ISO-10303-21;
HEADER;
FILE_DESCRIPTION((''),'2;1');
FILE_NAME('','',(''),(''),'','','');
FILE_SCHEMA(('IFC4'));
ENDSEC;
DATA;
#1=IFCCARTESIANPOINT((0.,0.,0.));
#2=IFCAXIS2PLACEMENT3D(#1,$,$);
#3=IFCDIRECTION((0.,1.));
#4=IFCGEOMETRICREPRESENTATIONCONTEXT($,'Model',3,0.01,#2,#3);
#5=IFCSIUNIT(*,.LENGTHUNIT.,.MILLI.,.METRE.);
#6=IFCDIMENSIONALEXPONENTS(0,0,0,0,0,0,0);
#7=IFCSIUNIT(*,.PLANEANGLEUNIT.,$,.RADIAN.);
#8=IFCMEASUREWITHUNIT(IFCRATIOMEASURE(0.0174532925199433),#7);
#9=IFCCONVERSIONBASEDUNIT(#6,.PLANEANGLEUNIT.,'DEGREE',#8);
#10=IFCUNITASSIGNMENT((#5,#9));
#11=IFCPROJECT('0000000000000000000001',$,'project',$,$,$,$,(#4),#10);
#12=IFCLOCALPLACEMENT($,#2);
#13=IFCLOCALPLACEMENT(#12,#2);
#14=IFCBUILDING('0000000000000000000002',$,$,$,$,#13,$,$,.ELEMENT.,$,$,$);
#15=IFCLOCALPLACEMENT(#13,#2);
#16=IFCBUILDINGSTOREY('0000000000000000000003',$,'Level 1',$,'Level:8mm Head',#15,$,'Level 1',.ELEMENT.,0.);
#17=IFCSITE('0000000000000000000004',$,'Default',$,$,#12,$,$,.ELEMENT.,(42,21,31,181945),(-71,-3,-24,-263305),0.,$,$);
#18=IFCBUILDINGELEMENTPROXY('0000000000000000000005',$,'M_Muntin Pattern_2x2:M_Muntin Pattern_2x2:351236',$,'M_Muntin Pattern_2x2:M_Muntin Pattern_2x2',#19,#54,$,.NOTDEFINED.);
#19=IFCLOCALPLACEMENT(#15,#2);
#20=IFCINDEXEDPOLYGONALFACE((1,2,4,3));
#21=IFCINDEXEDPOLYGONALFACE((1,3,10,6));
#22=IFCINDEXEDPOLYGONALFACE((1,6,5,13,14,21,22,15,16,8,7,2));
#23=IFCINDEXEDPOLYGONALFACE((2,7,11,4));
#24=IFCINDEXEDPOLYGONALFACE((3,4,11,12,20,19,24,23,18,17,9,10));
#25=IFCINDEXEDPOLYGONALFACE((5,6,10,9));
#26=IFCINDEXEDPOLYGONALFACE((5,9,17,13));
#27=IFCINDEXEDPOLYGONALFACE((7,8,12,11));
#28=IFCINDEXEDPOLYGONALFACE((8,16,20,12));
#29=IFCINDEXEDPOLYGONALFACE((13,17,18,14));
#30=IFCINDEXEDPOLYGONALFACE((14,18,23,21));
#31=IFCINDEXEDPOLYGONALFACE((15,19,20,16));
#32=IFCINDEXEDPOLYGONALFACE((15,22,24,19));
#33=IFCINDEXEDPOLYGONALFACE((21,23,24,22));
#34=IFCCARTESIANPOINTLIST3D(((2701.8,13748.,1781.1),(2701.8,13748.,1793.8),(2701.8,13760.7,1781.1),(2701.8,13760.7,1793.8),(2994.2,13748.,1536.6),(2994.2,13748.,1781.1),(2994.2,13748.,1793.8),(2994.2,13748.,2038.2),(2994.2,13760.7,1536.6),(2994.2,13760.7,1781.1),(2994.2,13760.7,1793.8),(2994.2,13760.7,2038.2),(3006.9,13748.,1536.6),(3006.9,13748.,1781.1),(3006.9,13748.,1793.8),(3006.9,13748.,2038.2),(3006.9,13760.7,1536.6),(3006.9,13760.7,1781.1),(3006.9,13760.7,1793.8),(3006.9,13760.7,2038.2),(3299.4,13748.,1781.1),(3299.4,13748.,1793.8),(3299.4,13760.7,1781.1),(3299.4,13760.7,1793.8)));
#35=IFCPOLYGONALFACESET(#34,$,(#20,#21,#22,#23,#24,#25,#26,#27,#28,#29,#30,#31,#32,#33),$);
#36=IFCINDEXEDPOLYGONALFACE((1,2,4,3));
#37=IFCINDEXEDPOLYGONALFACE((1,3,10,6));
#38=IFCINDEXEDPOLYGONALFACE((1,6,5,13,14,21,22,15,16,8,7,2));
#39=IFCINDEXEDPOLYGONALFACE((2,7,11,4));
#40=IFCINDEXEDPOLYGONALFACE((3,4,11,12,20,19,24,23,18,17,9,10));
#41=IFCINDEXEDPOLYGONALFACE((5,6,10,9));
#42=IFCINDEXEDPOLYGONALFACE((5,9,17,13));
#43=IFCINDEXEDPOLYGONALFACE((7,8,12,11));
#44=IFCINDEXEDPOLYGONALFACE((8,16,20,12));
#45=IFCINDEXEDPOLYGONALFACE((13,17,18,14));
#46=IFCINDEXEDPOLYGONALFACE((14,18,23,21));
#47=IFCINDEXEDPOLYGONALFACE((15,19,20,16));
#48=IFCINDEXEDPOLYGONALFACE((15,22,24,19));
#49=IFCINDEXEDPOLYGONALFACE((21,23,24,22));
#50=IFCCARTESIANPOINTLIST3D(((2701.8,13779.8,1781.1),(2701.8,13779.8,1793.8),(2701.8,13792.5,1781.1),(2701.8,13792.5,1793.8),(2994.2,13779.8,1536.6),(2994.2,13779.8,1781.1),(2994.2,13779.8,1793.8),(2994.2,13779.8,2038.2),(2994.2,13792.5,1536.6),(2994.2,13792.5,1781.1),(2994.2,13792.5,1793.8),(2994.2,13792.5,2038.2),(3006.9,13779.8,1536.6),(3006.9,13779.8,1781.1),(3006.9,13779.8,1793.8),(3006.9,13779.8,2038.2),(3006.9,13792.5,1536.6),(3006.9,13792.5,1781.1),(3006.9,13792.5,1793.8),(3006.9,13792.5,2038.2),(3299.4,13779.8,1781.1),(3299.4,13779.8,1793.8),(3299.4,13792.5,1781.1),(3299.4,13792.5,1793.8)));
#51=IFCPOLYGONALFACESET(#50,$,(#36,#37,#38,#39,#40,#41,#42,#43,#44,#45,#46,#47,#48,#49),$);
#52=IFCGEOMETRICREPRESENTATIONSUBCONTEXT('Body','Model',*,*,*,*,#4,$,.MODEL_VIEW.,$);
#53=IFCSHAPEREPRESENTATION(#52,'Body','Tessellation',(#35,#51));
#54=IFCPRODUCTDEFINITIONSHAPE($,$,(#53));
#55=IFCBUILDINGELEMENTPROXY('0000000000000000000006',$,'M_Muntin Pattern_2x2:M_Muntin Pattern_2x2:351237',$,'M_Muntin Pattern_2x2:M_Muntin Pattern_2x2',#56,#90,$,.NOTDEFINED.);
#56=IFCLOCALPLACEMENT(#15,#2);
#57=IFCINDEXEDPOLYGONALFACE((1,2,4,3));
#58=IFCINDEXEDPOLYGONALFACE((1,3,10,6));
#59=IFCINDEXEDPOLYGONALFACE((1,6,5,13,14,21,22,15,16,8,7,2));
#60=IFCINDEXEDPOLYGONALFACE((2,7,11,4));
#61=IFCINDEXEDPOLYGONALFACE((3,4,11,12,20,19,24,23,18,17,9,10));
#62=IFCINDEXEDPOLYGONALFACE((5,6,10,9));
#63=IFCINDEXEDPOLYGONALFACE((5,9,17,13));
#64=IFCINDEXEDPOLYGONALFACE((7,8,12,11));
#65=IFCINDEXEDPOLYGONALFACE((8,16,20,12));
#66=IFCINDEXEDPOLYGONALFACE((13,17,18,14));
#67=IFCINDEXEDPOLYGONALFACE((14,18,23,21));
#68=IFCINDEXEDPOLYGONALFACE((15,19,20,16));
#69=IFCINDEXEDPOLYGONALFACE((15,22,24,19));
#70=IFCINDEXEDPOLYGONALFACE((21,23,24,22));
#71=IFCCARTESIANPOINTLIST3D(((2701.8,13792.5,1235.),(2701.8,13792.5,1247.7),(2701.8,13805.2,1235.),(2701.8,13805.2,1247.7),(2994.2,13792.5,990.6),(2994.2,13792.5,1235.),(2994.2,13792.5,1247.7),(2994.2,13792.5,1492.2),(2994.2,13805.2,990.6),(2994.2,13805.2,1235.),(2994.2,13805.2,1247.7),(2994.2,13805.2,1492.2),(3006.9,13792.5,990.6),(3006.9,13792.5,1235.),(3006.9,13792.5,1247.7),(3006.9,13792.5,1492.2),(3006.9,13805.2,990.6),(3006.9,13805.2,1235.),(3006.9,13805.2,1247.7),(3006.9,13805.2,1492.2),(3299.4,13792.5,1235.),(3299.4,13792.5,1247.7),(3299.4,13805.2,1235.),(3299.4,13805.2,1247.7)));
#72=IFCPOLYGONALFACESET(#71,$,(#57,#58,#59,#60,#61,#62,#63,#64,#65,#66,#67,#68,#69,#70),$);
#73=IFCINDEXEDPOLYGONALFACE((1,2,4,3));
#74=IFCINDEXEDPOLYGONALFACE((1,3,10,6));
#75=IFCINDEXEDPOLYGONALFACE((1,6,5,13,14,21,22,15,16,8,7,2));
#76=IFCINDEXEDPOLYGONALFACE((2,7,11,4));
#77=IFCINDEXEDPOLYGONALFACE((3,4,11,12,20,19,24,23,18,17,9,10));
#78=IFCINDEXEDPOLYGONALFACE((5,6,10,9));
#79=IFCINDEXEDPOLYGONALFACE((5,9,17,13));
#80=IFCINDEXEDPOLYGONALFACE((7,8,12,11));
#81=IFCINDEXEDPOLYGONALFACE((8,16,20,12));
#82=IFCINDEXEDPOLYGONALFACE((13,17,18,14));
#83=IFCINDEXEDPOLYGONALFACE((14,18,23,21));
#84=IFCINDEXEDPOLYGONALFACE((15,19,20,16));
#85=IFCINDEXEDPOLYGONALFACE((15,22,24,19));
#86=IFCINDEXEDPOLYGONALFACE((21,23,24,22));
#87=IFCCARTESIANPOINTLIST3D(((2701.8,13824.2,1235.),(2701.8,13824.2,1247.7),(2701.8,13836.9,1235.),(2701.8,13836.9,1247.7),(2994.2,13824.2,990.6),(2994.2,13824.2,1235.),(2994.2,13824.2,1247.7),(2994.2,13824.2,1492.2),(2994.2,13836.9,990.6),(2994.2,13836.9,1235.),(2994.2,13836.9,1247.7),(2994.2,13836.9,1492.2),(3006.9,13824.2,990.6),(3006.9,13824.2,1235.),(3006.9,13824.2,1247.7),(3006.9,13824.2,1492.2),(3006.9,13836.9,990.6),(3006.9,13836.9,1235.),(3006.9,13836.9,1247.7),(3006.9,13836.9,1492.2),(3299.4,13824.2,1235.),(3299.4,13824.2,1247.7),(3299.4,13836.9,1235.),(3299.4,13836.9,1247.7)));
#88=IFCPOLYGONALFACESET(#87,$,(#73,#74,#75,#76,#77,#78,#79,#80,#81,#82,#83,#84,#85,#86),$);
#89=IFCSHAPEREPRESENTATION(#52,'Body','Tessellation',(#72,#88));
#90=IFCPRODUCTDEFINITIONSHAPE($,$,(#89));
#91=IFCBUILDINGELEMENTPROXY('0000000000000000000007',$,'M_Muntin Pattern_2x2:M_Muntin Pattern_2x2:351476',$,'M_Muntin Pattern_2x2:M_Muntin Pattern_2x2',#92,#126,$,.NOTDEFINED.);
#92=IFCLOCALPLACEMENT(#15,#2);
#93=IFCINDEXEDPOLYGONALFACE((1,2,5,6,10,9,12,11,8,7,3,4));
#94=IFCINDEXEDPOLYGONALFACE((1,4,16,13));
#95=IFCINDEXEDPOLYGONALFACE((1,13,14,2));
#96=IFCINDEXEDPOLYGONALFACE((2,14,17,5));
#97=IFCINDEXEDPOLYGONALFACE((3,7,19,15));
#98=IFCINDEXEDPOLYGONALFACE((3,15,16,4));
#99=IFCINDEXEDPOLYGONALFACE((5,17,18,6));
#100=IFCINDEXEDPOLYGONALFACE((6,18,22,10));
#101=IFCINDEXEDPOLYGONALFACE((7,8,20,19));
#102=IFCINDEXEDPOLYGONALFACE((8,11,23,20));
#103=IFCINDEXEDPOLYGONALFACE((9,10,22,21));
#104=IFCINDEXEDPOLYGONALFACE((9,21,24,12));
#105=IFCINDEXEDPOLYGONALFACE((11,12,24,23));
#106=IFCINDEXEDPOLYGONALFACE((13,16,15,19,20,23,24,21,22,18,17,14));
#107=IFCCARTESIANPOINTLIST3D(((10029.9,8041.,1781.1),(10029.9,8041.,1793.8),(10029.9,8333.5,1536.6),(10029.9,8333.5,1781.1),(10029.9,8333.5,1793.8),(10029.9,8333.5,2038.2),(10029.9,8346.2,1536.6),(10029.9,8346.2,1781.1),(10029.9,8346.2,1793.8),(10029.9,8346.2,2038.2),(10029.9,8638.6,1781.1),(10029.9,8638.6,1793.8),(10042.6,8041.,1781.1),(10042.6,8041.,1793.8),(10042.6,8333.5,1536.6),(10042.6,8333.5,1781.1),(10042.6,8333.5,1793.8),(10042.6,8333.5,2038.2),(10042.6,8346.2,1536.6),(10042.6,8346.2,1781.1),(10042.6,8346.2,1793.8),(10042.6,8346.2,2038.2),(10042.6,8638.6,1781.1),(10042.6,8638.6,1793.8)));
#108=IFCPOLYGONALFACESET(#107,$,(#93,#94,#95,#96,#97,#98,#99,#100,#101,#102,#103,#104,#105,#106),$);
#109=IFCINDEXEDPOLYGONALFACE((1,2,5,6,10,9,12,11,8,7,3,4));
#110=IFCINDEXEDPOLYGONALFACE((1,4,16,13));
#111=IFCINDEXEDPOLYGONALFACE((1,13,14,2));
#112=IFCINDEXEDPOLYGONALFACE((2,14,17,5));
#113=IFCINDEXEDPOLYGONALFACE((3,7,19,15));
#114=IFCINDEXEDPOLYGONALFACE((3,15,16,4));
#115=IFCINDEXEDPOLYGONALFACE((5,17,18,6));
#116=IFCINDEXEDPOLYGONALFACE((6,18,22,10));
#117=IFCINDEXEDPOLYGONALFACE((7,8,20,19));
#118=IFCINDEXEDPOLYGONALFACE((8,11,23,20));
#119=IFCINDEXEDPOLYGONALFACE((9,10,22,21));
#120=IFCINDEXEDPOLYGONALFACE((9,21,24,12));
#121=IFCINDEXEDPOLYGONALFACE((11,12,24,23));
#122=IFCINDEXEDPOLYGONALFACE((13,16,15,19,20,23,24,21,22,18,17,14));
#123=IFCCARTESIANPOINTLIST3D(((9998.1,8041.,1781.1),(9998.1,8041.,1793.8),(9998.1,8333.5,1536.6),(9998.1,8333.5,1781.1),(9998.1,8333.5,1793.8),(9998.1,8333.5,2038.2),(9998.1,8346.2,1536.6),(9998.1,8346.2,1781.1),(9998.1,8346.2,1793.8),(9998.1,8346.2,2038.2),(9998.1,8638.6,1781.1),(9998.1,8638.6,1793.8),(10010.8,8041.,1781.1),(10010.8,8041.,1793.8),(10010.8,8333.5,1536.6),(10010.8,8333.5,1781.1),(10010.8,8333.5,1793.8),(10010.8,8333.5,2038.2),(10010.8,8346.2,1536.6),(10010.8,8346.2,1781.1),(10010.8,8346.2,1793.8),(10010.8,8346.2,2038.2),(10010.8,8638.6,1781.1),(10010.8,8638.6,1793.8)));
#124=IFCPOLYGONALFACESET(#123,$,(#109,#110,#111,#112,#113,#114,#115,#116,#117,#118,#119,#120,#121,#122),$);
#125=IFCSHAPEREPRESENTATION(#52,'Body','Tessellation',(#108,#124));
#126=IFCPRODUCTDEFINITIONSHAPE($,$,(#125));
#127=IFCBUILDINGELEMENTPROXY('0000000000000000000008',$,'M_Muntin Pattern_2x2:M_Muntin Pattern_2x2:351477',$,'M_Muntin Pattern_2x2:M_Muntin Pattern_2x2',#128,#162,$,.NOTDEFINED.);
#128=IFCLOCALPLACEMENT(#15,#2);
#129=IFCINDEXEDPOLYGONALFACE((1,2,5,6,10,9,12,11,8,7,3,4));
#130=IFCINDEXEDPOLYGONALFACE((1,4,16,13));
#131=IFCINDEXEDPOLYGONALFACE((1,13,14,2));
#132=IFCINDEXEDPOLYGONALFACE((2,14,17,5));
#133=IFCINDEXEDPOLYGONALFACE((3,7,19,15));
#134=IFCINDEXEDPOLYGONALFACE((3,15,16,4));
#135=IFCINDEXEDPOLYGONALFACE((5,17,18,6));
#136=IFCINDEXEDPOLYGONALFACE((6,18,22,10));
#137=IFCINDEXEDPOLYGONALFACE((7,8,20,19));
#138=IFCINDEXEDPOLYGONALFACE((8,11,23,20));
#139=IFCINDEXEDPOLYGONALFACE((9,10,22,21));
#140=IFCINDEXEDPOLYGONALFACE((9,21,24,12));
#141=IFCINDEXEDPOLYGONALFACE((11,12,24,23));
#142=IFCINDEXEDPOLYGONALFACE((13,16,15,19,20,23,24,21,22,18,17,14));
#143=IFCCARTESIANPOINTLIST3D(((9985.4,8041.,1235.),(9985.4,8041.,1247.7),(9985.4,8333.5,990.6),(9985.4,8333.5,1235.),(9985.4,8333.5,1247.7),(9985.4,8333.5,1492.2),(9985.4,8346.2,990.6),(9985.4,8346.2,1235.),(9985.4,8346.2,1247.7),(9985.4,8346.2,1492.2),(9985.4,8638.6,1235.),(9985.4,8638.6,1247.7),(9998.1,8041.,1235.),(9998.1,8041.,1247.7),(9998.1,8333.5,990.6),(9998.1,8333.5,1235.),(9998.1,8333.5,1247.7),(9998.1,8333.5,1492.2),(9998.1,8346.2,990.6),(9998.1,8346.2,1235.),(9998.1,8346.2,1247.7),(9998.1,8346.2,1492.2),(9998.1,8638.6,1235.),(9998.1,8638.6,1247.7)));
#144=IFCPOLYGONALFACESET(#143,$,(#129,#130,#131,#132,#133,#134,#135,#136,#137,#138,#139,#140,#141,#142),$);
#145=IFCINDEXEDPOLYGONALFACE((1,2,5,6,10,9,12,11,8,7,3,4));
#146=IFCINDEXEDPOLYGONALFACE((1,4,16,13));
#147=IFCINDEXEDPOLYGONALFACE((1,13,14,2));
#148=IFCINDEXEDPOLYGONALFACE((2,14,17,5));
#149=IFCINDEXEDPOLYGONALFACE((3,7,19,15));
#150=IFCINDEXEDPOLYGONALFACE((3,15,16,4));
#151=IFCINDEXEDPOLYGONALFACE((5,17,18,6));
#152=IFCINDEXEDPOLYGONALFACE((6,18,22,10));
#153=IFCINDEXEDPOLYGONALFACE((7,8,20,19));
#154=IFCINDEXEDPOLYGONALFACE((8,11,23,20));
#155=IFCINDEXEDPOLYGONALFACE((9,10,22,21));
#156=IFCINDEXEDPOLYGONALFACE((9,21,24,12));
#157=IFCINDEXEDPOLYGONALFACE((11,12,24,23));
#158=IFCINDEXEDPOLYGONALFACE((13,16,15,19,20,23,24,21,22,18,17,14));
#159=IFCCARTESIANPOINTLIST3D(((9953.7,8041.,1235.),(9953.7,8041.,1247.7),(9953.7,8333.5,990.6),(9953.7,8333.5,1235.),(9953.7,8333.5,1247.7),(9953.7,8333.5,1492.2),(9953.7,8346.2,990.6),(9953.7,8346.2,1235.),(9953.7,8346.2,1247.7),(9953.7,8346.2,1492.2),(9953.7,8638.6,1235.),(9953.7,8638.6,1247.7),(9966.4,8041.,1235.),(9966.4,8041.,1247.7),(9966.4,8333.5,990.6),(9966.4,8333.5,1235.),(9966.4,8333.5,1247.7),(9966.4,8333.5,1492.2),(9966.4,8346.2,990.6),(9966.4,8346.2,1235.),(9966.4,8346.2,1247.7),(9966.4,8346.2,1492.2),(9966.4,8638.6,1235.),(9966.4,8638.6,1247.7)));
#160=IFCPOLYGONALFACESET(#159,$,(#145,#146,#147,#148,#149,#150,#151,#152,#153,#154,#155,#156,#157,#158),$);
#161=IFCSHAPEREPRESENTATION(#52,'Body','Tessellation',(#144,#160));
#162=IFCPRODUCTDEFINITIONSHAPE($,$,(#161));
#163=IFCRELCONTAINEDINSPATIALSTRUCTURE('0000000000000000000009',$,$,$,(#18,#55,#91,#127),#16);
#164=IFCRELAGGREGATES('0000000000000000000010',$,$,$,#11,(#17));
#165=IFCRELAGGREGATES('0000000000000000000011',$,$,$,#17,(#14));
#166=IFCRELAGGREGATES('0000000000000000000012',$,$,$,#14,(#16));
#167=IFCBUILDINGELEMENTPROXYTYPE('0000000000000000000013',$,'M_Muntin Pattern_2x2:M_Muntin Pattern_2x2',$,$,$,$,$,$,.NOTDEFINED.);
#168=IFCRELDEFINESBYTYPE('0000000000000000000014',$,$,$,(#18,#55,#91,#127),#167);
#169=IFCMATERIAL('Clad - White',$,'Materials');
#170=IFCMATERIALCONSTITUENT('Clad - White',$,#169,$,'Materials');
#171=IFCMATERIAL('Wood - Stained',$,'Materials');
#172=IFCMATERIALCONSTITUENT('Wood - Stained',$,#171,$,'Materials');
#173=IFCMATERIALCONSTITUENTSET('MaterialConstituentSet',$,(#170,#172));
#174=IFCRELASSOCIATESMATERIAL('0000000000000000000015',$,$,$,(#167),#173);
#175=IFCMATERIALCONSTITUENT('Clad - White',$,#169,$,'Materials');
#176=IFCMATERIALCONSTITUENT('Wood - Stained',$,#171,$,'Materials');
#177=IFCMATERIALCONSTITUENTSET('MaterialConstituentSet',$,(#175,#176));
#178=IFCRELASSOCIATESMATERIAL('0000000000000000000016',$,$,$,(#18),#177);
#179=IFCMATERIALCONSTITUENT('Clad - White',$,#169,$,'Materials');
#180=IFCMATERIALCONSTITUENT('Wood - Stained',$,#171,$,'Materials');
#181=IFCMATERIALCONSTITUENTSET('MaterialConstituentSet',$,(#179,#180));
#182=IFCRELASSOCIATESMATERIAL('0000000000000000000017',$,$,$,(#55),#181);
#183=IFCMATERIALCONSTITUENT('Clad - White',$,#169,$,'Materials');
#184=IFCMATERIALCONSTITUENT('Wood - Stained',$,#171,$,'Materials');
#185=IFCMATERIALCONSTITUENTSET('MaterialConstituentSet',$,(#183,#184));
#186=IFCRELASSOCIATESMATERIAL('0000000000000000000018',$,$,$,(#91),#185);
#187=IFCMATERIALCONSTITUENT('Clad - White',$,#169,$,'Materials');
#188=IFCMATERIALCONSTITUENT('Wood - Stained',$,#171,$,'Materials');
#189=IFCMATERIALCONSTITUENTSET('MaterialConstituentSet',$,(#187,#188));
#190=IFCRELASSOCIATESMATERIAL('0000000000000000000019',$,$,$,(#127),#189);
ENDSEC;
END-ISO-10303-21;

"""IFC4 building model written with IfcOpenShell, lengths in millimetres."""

from ifc_helpers import new_model, entity, si_unit, converted_unit, direction, frame, origin, place, context, subcontext, project, spatial, polyline, outline, extrude, source, transform, mapped, material, constituent, constituent_set, type_object, type_shapes, element, save


model = new_model("IFC4")

# Units and contexts
model_context = context("Model", 3, precision=0.01, world=origin(), true_north=direction((0.0, 1.0)))
body_context = subcontext(model_context, "Body", "Model", "MODEL_VIEW")
ifc_project = project(units=[si_unit("LENGTHUNIT", "METRE", prefix="MILLI"), converted_unit("PLANEANGLEUNIT", "DEGREE", entity("IfcRatioMeasure", 0.0174532925199433), si_unit("PLANEANGLEUNIT", "RADIAN"), dimensions=[0, 0, 0, 0, 0, 0, 0])], contexts=[model_context])

# Site, building, storey
site_placement = place(None, origin())
site = spatial("IfcSite", under=ifc_project, at=site_placement, Name="Default", CompositionType="ELEMENT", RefLatitude=(42, 21, 31, 181945), RefLongitude=(-71, -3, -24, -263305), RefElevation=0.0)
building_placement = place(site_placement, origin())
building = spatial("IfcBuilding", under=site, at=building_placement, CompositionType="ELEMENT")
storey_placement = place(building_placement, origin())
storey = spatial("IfcBuildingStorey", under=building, at=storey_placement, Name="Level 1", ObjectType="Level:8mm Head", LongName="Level 1", CompositionType="ELEMENT", Elevation=0.0)

# Shared definitions
ifc_material_1 = material(Name="Wood - Stained", Category="Materials")

# Building element proxies
ifc_material_2 = material(Name="Clad - White", Category="Materials")
ifc_constituent_1 = constituent(ifc_material_2, Name="Clad - White", Category="Materials")
ifc_constituent_2 = constituent(ifc_material_1, Name="Wood - Stained", Category="Materials")
ifc_constituent_set_1 = constituent_set(constituents=[ifc_constituent_1, ifc_constituent_2], Name="MaterialConstituentSet")
building_element_proxy_type_1 = type_object("IfcBuildingElementProxyType", Name="M_Muntin Pattern_2x2:M_Muntin Pattern_2x2", PredefinedType="NOTDEFINED", material=ifc_constituent_set_1)
shared_shape_1 = source(origin(), body_context, "Body", "SweptSolid", [
    extrude(outline(polyline([(6.4, -6.4), (250.8, -6.4), (250.8, 6.3), (6.4, 6.3), (6.4, 298.8), (-6.3, 298.8), (-6.3, 6.3), (-250.8, 6.3), (-250.8, -6.4), (-6.3, -6.4), (-6.3, -298.8), (6.4, -298.8), (6.4, -6.4)])), frame((0.0, 9.5, 250.8), z_axis=(0.0, 1.0, 0.0), x_axis=(0.0, 0.0, 1.0)), (0.0, 0.0, 1.0), 12.7),
    extrude(outline(polyline([(6.4, -6.4), (250.8, -6.4), (250.8, 6.3), (6.4, 6.3), (6.4, 298.8), (-6.3, 298.8), (-6.3, 6.3), (-250.8, 6.3), (-250.8, -6.4), (-6.3, -6.4), (-6.3, -298.8), (6.4, -298.8), (6.4, -6.4)])), frame((0.0, -22.2, 250.8), z_axis=(0.0, 1.0, 0.0), x_axis=(0.0, 0.0, 1.0)), (0.0, 0.0, 1.0), 12.7),
])
type_shapes(building_element_proxy_type_1, [shared_shape_1])
ifc_constituent_3 = constituent(ifc_material_2, Name="Clad - White", Category="Materials")
ifc_constituent_4 = constituent(ifc_material_1, Name="Wood - Stained", Category="Materials")
ifc_constituent_set_2 = constituent_set(constituents=[ifc_constituent_3, ifc_constituent_4], Name="MaterialConstituentSet")
proxy_1_placement = place(storey_placement, frame((3000.6, 13770.3, 1536.6), z_axis=(0.0, 0.0, 1.0), x_axis=(-1.0, 0.0, 0.0)))
element("IfcBuildingElementProxy", 1, at=proxy_1_placement, inside=storey, type_object=building_element_proxy_type_1, material=ifc_constituent_set_2, Name="M_Muntin Pattern_2x2:M_Muntin Pattern_2x2:351236", ObjectType="M_Muntin Pattern_2x2:M_Muntin Pattern_2x2", PredefinedType="NOTDEFINED", context=body_context, shape_type="MappedRepresentation", body=[
    mapped(shared_shape_1, transform((0.0, 0.0, 0.0), scale=1.0)),
])
ifc_constituent_5 = constituent(ifc_material_2, Name="Clad - White", Category="Materials")
ifc_constituent_6 = constituent(ifc_material_1, Name="Wood - Stained", Category="Materials")
ifc_constituent_set_3 = constituent_set(constituents=[ifc_constituent_5, ifc_constituent_6], Name="MaterialConstituentSet")
proxy_2_placement = place(storey_placement, frame((3000.6, 13814.7, 990.6), z_axis=(0.0, 0.0, 1.0), x_axis=(-1.0, 0.0, 0.0)))
element("IfcBuildingElementProxy", 2, at=proxy_2_placement, inside=storey, type_object=building_element_proxy_type_1, material=ifc_constituent_set_3, Name="M_Muntin Pattern_2x2:M_Muntin Pattern_2x2:351237", ObjectType="M_Muntin Pattern_2x2:M_Muntin Pattern_2x2", PredefinedType="NOTDEFINED", context=body_context, shape_type="MappedRepresentation", body=[
    mapped(shared_shape_1, transform((0.0, 0.0, 0.0), scale=1.0)),
])
ifc_constituent_7 = constituent(ifc_material_2, Name="Clad - White", Category="Materials")
ifc_constituent_8 = constituent(ifc_material_1, Name="Wood - Stained", Category="Materials")
ifc_constituent_set_4 = constituent_set(constituents=[ifc_constituent_7, ifc_constituent_8], Name="MaterialConstituentSet")
proxy_3_placement = place(storey_placement, frame((10020.3, 8339.8, 1536.6), z_axis=(0.0, 0.0, 1.0), x_axis=(0.0, -1.0, 0.0)))
element("IfcBuildingElementProxy", 3, at=proxy_3_placement, inside=storey, type_object=building_element_proxy_type_1, material=ifc_constituent_set_4, Name="M_Muntin Pattern_2x2:M_Muntin Pattern_2x2:351476", ObjectType="M_Muntin Pattern_2x2:M_Muntin Pattern_2x2", PredefinedType="NOTDEFINED", context=body_context, shape_type="MappedRepresentation", body=[
    mapped(shared_shape_1, transform((0.0, 0.0, 0.0), scale=1.0)),
])
ifc_constituent_9 = constituent(ifc_material_2, Name="Clad - White", Category="Materials")
ifc_constituent_10 = constituent(ifc_material_1, Name="Wood - Stained", Category="Materials")
ifc_constituent_set_5 = constituent_set(constituents=[ifc_constituent_9, ifc_constituent_10], Name="MaterialConstituentSet")
proxy_4_placement = place(storey_placement, frame((9975.9, 8339.8, 990.6), z_axis=(0.0, 0.0, 1.0), x_axis=(0.0, -1.0, 0.0)))
element("IfcBuildingElementProxy", 4, at=proxy_4_placement, inside=storey, type_object=building_element_proxy_type_1, material=ifc_constituent_set_5, Name="M_Muntin Pattern_2x2:M_Muntin Pattern_2x2:351477", ObjectType="M_Muntin Pattern_2x2:M_Muntin Pattern_2x2", PredefinedType="NOTDEFINED", context=body_context, shape_type="MappedRepresentation", body=[
    mapped(shared_shape_1, transform((0.0, 0.0, 0.0), scale=1.0)),
])

save(model, "model.ifc")
